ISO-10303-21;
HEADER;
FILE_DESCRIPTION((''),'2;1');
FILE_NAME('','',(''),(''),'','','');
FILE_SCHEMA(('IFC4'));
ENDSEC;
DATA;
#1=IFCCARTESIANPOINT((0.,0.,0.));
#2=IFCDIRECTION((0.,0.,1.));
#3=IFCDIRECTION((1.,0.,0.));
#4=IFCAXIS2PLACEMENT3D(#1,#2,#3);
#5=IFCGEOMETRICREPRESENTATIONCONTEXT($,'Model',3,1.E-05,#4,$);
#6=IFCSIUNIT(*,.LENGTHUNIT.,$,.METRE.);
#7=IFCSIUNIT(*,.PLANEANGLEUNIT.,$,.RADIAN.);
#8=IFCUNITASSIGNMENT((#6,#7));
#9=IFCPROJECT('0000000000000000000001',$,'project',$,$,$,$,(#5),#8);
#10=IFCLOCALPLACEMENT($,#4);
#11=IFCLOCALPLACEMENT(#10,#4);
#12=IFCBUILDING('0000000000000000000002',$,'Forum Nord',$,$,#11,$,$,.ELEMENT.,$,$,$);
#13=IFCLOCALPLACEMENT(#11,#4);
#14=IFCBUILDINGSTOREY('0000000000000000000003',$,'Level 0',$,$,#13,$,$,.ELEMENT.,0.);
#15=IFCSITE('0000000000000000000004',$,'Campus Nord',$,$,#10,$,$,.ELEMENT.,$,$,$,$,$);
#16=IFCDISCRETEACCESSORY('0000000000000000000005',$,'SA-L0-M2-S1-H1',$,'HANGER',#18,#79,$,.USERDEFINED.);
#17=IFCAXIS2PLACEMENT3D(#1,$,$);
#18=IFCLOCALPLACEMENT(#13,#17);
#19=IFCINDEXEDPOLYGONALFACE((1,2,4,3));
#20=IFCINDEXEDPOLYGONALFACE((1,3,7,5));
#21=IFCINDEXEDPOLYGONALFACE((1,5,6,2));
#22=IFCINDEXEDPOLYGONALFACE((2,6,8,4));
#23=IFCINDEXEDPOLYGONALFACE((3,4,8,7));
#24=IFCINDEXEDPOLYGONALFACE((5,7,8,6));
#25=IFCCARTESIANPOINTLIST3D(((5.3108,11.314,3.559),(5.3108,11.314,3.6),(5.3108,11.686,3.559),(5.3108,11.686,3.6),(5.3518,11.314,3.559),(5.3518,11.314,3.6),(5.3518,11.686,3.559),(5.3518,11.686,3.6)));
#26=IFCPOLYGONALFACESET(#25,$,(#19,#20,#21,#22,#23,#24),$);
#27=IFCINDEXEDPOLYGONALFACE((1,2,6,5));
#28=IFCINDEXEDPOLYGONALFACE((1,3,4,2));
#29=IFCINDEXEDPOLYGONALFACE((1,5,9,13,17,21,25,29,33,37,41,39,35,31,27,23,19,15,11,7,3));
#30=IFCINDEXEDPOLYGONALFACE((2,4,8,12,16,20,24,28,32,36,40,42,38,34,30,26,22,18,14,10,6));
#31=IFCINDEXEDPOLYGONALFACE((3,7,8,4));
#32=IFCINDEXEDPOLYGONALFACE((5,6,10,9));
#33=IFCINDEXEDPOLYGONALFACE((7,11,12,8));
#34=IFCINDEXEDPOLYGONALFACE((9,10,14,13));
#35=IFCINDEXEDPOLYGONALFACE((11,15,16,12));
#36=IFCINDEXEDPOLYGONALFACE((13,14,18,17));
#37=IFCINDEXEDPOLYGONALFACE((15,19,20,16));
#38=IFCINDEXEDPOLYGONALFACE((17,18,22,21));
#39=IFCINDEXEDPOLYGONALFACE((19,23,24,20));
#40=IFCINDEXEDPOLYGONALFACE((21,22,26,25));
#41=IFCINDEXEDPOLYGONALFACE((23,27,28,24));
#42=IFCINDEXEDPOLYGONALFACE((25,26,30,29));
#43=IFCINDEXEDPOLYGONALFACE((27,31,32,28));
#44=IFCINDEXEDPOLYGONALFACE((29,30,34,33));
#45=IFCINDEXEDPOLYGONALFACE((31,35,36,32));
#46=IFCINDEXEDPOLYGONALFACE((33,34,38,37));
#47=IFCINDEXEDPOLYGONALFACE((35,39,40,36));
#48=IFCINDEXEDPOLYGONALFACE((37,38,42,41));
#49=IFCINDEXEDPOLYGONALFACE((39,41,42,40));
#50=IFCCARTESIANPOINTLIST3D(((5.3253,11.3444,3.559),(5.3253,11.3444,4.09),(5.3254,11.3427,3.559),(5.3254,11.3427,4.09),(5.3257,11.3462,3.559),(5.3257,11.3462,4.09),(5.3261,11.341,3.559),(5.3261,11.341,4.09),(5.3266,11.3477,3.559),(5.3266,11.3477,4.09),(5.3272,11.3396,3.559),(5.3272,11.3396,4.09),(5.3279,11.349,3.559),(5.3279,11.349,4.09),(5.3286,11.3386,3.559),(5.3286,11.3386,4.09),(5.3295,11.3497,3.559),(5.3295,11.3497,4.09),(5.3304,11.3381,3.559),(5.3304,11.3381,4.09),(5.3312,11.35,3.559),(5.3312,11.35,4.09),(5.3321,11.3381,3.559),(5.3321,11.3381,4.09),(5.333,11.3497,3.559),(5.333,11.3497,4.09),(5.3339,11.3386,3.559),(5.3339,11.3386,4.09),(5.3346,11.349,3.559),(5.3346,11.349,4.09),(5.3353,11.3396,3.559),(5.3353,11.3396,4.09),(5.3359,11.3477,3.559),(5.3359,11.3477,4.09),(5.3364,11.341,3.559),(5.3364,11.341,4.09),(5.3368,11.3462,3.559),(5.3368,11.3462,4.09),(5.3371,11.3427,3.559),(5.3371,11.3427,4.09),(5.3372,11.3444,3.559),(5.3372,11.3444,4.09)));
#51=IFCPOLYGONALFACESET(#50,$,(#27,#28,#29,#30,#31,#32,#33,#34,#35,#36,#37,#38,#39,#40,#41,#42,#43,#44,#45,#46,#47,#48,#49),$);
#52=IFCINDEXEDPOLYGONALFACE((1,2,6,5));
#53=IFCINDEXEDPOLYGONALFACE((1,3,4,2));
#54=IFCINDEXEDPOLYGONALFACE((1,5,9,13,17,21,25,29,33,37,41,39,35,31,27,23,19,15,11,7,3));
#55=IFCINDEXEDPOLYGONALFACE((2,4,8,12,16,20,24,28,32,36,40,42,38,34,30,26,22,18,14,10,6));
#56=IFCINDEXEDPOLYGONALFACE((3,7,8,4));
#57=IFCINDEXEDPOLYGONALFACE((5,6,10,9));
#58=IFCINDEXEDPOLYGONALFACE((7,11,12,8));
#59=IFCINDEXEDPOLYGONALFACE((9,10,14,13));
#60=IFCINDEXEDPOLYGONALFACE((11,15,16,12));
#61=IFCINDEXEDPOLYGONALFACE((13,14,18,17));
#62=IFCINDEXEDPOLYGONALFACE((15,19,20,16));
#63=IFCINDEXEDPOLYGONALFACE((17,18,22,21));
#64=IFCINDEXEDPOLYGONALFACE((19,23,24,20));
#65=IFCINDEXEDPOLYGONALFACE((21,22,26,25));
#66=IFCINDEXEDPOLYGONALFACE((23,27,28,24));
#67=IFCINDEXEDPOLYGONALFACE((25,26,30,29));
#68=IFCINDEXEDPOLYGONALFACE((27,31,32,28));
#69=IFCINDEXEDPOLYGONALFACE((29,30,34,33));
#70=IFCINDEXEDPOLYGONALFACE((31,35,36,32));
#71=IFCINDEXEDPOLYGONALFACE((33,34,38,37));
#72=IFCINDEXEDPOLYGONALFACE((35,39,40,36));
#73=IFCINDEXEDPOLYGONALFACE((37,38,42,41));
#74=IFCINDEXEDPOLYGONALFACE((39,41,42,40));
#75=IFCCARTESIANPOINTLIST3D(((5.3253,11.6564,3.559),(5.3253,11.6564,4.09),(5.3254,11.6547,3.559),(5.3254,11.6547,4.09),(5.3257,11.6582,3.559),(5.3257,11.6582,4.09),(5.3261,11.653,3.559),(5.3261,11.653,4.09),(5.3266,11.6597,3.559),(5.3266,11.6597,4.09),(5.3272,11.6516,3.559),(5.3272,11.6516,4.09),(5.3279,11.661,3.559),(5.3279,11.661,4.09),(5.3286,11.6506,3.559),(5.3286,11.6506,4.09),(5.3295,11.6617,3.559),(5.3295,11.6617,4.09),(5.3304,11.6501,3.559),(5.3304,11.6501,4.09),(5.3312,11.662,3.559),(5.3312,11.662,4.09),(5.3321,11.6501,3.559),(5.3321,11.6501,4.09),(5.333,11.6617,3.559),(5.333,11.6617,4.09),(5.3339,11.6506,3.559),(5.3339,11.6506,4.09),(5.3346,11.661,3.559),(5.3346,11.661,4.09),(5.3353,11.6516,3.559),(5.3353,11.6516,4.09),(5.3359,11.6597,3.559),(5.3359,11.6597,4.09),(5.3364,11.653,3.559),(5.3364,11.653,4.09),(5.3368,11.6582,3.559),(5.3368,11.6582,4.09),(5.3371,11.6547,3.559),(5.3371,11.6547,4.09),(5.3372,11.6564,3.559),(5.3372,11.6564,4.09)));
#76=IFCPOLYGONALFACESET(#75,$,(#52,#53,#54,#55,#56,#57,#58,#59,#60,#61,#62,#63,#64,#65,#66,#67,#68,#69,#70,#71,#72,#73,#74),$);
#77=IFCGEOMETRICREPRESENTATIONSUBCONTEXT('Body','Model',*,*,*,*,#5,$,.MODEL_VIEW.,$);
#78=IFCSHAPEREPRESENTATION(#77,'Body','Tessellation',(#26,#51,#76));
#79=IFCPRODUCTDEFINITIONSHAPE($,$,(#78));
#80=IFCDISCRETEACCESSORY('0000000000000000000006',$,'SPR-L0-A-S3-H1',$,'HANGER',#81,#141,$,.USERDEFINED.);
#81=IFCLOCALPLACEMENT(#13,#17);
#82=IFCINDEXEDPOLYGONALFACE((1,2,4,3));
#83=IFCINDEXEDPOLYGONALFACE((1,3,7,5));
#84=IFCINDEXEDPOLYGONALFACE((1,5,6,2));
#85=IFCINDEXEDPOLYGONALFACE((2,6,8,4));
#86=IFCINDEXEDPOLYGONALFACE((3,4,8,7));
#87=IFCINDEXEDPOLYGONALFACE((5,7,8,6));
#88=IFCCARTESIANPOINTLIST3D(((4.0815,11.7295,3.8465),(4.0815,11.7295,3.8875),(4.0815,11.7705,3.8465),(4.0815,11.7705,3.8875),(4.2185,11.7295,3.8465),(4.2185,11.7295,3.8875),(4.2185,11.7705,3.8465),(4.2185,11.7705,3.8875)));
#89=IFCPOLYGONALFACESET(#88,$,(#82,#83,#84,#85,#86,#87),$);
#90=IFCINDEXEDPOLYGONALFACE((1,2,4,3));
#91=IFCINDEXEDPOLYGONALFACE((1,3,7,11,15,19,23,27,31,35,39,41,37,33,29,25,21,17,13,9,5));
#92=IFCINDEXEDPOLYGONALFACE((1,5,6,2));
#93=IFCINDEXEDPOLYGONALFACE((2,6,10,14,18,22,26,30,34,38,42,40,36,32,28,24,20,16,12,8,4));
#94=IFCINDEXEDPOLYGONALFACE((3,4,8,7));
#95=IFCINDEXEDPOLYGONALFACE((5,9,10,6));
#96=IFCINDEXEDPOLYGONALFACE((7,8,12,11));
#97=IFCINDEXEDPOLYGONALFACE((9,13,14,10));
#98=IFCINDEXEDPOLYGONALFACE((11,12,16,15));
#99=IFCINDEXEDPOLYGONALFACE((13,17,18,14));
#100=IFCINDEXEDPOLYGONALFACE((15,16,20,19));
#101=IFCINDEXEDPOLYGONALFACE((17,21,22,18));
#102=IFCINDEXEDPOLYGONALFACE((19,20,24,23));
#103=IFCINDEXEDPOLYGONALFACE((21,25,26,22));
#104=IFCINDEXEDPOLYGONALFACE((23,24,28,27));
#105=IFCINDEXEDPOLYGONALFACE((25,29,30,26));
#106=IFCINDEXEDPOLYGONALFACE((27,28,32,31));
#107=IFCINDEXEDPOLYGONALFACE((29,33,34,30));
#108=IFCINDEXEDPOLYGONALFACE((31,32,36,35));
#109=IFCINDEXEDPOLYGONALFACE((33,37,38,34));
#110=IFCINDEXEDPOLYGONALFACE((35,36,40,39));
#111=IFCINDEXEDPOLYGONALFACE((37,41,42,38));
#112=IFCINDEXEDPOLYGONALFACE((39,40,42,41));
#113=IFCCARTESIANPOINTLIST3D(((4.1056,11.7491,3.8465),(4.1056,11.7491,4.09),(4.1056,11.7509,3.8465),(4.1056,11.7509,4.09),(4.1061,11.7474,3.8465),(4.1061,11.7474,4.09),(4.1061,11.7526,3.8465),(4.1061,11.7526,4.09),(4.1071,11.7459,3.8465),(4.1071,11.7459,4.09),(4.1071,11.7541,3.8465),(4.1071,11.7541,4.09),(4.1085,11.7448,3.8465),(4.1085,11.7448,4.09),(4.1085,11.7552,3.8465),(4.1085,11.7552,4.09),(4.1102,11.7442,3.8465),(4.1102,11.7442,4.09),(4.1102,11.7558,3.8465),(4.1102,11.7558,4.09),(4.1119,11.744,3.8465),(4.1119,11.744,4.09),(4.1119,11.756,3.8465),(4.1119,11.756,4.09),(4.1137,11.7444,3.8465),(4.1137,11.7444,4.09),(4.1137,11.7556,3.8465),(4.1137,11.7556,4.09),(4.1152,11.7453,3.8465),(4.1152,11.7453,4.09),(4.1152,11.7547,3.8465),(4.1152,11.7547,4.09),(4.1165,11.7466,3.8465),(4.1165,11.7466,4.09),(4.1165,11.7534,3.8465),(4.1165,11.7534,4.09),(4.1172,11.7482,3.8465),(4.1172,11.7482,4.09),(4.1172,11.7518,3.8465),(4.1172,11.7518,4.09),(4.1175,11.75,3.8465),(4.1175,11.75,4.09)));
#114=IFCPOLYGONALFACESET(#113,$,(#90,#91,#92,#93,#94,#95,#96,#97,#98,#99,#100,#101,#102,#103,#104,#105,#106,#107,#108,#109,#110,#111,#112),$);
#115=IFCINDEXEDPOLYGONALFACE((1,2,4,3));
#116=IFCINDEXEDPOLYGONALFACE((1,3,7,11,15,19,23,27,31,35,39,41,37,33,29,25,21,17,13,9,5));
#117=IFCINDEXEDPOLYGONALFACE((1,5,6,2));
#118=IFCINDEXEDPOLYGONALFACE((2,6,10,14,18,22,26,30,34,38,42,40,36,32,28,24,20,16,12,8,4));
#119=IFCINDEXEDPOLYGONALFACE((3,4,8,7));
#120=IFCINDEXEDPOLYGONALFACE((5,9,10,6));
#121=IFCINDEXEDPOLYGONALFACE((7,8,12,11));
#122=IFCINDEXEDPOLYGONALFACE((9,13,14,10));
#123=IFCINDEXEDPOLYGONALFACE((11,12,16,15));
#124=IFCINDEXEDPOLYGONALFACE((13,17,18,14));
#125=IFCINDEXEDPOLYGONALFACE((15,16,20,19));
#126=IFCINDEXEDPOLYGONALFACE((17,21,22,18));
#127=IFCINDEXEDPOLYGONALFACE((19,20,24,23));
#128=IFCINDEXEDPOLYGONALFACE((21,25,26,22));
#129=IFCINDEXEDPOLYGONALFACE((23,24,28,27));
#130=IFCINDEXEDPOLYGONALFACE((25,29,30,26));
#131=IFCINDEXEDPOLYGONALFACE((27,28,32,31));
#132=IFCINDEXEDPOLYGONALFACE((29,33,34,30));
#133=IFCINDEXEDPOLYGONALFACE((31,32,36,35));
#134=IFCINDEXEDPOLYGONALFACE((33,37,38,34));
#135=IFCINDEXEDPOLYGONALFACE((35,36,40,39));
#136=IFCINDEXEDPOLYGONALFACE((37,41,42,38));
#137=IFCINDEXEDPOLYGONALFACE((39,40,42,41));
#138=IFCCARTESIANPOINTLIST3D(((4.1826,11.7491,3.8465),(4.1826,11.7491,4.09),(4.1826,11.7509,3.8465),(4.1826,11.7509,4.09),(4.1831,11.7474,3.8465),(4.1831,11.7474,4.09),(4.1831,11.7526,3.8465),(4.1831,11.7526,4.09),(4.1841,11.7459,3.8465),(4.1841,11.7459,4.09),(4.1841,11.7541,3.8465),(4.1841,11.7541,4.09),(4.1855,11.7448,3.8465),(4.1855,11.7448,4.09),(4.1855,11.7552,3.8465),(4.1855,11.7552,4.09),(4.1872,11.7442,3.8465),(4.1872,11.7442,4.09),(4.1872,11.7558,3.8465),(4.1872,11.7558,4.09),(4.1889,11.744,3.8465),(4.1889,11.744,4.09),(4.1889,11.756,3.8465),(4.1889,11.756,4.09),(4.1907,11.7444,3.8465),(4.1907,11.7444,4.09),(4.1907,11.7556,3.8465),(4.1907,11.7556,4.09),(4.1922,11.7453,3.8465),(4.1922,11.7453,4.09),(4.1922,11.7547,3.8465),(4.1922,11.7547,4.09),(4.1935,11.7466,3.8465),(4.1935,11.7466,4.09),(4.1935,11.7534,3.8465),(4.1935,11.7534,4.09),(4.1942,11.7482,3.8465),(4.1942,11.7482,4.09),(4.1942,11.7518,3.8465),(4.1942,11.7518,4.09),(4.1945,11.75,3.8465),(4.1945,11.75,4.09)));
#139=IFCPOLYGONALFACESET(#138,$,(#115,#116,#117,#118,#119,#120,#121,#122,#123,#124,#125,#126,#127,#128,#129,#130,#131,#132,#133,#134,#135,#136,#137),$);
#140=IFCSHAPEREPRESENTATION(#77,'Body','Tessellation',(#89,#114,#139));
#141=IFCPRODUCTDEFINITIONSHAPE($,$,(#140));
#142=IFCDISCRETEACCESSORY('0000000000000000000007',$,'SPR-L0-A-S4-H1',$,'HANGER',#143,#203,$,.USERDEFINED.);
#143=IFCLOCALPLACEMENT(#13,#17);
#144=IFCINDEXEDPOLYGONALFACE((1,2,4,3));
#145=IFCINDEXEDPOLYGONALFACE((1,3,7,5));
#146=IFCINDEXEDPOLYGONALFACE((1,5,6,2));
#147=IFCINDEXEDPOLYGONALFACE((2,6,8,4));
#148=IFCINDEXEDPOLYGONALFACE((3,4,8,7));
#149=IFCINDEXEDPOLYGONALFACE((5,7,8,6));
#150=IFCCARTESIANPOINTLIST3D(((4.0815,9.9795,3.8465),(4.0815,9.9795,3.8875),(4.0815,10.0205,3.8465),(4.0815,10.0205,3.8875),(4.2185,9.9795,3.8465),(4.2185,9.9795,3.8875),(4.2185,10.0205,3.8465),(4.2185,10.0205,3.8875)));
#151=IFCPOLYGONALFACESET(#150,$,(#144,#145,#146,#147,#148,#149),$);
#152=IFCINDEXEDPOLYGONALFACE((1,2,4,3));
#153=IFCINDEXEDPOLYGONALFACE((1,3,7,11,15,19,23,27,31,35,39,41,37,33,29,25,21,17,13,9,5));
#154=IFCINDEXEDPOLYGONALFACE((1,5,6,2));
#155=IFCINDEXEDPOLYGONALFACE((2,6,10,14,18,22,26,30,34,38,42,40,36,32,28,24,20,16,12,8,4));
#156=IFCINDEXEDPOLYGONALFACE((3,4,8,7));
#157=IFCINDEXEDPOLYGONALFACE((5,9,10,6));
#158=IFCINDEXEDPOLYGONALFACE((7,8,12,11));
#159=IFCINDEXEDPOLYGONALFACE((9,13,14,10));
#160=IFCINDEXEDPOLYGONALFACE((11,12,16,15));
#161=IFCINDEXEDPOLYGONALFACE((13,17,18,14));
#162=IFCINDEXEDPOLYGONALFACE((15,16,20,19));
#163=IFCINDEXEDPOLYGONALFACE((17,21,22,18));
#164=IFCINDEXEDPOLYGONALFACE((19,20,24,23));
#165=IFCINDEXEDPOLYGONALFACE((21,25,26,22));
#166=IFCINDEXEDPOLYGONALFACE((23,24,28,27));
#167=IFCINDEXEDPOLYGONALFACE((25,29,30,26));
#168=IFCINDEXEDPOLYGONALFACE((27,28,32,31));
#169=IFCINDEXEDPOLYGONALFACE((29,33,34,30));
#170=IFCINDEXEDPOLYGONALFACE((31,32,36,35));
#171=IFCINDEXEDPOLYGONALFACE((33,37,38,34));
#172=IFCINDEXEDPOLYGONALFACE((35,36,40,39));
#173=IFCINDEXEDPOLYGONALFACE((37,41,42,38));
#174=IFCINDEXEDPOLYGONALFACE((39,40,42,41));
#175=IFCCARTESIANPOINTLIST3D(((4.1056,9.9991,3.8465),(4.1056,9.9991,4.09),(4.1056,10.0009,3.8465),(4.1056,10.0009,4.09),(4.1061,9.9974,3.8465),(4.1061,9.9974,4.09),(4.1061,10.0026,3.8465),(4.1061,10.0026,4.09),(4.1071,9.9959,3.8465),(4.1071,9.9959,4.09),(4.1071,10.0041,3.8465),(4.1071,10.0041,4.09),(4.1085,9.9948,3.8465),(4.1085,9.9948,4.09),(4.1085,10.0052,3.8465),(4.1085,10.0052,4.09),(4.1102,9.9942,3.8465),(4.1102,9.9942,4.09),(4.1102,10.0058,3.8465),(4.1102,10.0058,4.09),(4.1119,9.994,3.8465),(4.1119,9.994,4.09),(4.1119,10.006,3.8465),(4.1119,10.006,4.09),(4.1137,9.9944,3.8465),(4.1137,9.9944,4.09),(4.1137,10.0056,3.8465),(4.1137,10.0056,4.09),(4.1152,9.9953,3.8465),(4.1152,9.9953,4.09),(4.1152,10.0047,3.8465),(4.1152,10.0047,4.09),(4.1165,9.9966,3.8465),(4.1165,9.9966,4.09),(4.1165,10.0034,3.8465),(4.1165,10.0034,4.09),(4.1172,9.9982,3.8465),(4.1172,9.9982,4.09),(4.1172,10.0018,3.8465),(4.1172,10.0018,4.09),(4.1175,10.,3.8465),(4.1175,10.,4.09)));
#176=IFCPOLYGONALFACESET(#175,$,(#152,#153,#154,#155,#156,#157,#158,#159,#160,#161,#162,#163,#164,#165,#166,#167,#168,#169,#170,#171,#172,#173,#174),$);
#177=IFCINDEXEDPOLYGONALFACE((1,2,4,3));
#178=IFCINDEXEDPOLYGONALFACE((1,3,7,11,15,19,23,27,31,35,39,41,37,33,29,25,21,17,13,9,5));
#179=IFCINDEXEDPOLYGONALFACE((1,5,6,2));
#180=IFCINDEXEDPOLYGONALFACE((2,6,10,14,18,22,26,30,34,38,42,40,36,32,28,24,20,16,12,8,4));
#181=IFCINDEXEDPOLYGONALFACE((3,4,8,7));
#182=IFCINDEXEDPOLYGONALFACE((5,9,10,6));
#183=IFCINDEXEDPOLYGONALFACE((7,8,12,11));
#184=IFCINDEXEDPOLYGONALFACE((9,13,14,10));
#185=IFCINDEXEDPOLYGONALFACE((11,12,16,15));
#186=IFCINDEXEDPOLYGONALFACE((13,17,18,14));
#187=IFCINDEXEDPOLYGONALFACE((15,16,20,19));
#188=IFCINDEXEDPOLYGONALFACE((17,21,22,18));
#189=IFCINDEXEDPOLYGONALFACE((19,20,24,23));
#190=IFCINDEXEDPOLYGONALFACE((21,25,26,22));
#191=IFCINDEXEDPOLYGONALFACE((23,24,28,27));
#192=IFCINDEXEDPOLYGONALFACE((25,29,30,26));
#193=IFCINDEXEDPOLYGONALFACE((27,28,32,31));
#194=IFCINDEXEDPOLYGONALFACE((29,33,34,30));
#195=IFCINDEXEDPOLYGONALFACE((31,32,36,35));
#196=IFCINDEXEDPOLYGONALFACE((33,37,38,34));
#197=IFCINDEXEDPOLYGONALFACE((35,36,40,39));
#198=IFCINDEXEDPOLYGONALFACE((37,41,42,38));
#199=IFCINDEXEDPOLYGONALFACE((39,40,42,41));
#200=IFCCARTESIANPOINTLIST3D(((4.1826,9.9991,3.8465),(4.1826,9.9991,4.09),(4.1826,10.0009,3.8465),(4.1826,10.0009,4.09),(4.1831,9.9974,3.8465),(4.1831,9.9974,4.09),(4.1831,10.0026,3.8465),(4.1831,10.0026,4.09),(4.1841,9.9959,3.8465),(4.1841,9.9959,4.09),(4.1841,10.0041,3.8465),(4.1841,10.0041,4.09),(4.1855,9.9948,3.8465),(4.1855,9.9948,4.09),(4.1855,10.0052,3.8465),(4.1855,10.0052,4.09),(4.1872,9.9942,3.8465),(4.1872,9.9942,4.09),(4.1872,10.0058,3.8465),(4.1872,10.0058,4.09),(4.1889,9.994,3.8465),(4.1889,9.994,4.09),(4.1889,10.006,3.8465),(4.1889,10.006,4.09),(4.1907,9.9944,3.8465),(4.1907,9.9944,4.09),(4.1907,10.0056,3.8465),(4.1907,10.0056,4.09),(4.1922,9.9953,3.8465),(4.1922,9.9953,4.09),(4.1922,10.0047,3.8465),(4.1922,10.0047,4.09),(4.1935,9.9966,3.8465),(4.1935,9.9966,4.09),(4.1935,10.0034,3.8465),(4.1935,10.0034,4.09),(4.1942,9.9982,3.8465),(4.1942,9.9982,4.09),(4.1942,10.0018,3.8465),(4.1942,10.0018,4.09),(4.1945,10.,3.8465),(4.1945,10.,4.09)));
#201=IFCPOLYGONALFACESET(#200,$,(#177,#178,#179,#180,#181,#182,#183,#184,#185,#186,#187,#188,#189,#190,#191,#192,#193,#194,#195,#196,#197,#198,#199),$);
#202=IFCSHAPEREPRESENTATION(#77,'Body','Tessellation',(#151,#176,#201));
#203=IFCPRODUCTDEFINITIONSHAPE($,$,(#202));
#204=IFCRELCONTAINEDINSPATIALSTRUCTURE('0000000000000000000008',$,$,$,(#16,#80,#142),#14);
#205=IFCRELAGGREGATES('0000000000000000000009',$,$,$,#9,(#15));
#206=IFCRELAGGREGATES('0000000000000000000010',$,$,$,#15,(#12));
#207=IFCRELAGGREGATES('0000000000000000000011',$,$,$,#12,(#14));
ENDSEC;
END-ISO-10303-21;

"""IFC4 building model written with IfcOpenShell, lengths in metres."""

from ifc_helpers import new_model, si_unit, frame, frame_2d, origin_with_axes, origin_2d_with_axis, place, context, subcontext, project, spatial, rectangle, circle, extrude, element, save


model = new_model("IFC4")

# Units and contexts
model_context = context("Model", 3, precision=1e-05, world=origin_with_axes())
body_context = subcontext(model_context, "Body", "Model", "MODEL_VIEW")
ifc_project = project(units=[si_unit("LENGTHUNIT", "METRE"), si_unit("PLANEANGLEUNIT", "RADIAN")], contexts=[model_context])

# Site, building, storey
site_placement = place(None, origin_with_axes())
site = spatial("IfcSite", under=ifc_project, at=site_placement, Name="Campus Nord", CompositionType="ELEMENT")
building_placement = place(site_placement, origin_with_axes())
building = spatial("IfcBuilding", under=site, at=building_placement, Name="Forum Nord", CompositionType="ELEMENT")
storey_placement = place(building_placement, origin_with_axes())
storey = spatial("IfcBuildingStorey", under=building, at=storey_placement, Name="Level 0", CompositionType="ELEMENT", Elevation=0.0)

# Discrete accessories
for number, where, z_axis, x_axis, name in (
    (1, (5.3312, 11.5, 3.6), (0.0, 0.0, 1.0), (0.0, 1.0, 0.0), "SA-L0-M2-S1-H1"),
):
    element("IfcDiscreteAccessory", number, at=place(storey_placement, frame(where, z_axis=z_axis, x_axis=x_axis)), inside=storey, Name=name, ObjectType="HANGER", PredefinedType="USERDEFINED", context=body_context, shape_type="SweptSolid", body=[
        extrude(rectangle(XDim=0.372, YDim=0.041, at=origin_2d_with_axis()), frame((0.0, 0.0, -0.041), z_axis=(0.0, 0.0, 1.0), x_axis=(1.0, 0.0, 0.0)), (0.0, 0.0, 1.0), 0.041),
        extrude(circle(Radius=0.006, at=frame_2d((-0.156, 0.0), x_axis=(1.0, 0.0))), frame((0.0, 0.0, -0.041), z_axis=(0.0, 0.0, 1.0), x_axis=(1.0, 0.0, 0.0)), (0.0, 0.0, 1.0), 0.531),
        extrude(circle(Radius=0.006, at=frame_2d((0.156, 0.0), x_axis=(1.0, 0.0))), frame((0.0, 0.0, -0.041), z_axis=(0.0, 0.0, 1.0), x_axis=(1.0, 0.0, 0.0)), (0.0, 0.0, 1.0), 0.531),
    ])
for number, where, z_axis, x_axis, name in (
    (2, (4.15, 11.75, 3.8875), (0.0, 0.0, 1.0), (1.0, 0.0, 0.0), "SPR-L0-A-S3-H1"),
    (3, (4.15, 10.0, 3.8875), (0.0, 0.0, 1.0), (1.0, 0.0, 0.0), "SPR-L0-A-S4-H1"),
):
    element("IfcDiscreteAccessory", number, at=place(storey_placement, frame(where, z_axis=z_axis, x_axis=x_axis)), inside=storey, Name=name, ObjectType="HANGER", PredefinedType="USERDEFINED", context=body_context, shape_type="SweptSolid", body=[
        extrude(rectangle(XDim=0.137, YDim=0.041, at=origin_2d_with_axis()), frame((0.0, 0.0, -0.041), z_axis=(0.0, 0.0, 1.0), x_axis=(1.0, 0.0, 0.0)), (0.0, 0.0, 1.0), 0.041),
        extrude(circle(Radius=0.006, at=frame_2d((-0.0385, 0.0), x_axis=(1.0, 0.0))), frame((0.0, 0.0, -0.041), z_axis=(0.0, 0.0, 1.0), x_axis=(1.0, 0.0, 0.0)), (0.0, 0.0, 1.0), 0.2435),
        extrude(circle(Radius=0.006, at=frame_2d((0.0385, 0.0), x_axis=(1.0, 0.0))), frame((0.0, 0.0, -0.041), z_axis=(0.0, 0.0, 1.0), x_axis=(1.0, 0.0, 0.0)), (0.0, 0.0, 1.0), 0.2435),
    ])

save(model, "model.ifc")
